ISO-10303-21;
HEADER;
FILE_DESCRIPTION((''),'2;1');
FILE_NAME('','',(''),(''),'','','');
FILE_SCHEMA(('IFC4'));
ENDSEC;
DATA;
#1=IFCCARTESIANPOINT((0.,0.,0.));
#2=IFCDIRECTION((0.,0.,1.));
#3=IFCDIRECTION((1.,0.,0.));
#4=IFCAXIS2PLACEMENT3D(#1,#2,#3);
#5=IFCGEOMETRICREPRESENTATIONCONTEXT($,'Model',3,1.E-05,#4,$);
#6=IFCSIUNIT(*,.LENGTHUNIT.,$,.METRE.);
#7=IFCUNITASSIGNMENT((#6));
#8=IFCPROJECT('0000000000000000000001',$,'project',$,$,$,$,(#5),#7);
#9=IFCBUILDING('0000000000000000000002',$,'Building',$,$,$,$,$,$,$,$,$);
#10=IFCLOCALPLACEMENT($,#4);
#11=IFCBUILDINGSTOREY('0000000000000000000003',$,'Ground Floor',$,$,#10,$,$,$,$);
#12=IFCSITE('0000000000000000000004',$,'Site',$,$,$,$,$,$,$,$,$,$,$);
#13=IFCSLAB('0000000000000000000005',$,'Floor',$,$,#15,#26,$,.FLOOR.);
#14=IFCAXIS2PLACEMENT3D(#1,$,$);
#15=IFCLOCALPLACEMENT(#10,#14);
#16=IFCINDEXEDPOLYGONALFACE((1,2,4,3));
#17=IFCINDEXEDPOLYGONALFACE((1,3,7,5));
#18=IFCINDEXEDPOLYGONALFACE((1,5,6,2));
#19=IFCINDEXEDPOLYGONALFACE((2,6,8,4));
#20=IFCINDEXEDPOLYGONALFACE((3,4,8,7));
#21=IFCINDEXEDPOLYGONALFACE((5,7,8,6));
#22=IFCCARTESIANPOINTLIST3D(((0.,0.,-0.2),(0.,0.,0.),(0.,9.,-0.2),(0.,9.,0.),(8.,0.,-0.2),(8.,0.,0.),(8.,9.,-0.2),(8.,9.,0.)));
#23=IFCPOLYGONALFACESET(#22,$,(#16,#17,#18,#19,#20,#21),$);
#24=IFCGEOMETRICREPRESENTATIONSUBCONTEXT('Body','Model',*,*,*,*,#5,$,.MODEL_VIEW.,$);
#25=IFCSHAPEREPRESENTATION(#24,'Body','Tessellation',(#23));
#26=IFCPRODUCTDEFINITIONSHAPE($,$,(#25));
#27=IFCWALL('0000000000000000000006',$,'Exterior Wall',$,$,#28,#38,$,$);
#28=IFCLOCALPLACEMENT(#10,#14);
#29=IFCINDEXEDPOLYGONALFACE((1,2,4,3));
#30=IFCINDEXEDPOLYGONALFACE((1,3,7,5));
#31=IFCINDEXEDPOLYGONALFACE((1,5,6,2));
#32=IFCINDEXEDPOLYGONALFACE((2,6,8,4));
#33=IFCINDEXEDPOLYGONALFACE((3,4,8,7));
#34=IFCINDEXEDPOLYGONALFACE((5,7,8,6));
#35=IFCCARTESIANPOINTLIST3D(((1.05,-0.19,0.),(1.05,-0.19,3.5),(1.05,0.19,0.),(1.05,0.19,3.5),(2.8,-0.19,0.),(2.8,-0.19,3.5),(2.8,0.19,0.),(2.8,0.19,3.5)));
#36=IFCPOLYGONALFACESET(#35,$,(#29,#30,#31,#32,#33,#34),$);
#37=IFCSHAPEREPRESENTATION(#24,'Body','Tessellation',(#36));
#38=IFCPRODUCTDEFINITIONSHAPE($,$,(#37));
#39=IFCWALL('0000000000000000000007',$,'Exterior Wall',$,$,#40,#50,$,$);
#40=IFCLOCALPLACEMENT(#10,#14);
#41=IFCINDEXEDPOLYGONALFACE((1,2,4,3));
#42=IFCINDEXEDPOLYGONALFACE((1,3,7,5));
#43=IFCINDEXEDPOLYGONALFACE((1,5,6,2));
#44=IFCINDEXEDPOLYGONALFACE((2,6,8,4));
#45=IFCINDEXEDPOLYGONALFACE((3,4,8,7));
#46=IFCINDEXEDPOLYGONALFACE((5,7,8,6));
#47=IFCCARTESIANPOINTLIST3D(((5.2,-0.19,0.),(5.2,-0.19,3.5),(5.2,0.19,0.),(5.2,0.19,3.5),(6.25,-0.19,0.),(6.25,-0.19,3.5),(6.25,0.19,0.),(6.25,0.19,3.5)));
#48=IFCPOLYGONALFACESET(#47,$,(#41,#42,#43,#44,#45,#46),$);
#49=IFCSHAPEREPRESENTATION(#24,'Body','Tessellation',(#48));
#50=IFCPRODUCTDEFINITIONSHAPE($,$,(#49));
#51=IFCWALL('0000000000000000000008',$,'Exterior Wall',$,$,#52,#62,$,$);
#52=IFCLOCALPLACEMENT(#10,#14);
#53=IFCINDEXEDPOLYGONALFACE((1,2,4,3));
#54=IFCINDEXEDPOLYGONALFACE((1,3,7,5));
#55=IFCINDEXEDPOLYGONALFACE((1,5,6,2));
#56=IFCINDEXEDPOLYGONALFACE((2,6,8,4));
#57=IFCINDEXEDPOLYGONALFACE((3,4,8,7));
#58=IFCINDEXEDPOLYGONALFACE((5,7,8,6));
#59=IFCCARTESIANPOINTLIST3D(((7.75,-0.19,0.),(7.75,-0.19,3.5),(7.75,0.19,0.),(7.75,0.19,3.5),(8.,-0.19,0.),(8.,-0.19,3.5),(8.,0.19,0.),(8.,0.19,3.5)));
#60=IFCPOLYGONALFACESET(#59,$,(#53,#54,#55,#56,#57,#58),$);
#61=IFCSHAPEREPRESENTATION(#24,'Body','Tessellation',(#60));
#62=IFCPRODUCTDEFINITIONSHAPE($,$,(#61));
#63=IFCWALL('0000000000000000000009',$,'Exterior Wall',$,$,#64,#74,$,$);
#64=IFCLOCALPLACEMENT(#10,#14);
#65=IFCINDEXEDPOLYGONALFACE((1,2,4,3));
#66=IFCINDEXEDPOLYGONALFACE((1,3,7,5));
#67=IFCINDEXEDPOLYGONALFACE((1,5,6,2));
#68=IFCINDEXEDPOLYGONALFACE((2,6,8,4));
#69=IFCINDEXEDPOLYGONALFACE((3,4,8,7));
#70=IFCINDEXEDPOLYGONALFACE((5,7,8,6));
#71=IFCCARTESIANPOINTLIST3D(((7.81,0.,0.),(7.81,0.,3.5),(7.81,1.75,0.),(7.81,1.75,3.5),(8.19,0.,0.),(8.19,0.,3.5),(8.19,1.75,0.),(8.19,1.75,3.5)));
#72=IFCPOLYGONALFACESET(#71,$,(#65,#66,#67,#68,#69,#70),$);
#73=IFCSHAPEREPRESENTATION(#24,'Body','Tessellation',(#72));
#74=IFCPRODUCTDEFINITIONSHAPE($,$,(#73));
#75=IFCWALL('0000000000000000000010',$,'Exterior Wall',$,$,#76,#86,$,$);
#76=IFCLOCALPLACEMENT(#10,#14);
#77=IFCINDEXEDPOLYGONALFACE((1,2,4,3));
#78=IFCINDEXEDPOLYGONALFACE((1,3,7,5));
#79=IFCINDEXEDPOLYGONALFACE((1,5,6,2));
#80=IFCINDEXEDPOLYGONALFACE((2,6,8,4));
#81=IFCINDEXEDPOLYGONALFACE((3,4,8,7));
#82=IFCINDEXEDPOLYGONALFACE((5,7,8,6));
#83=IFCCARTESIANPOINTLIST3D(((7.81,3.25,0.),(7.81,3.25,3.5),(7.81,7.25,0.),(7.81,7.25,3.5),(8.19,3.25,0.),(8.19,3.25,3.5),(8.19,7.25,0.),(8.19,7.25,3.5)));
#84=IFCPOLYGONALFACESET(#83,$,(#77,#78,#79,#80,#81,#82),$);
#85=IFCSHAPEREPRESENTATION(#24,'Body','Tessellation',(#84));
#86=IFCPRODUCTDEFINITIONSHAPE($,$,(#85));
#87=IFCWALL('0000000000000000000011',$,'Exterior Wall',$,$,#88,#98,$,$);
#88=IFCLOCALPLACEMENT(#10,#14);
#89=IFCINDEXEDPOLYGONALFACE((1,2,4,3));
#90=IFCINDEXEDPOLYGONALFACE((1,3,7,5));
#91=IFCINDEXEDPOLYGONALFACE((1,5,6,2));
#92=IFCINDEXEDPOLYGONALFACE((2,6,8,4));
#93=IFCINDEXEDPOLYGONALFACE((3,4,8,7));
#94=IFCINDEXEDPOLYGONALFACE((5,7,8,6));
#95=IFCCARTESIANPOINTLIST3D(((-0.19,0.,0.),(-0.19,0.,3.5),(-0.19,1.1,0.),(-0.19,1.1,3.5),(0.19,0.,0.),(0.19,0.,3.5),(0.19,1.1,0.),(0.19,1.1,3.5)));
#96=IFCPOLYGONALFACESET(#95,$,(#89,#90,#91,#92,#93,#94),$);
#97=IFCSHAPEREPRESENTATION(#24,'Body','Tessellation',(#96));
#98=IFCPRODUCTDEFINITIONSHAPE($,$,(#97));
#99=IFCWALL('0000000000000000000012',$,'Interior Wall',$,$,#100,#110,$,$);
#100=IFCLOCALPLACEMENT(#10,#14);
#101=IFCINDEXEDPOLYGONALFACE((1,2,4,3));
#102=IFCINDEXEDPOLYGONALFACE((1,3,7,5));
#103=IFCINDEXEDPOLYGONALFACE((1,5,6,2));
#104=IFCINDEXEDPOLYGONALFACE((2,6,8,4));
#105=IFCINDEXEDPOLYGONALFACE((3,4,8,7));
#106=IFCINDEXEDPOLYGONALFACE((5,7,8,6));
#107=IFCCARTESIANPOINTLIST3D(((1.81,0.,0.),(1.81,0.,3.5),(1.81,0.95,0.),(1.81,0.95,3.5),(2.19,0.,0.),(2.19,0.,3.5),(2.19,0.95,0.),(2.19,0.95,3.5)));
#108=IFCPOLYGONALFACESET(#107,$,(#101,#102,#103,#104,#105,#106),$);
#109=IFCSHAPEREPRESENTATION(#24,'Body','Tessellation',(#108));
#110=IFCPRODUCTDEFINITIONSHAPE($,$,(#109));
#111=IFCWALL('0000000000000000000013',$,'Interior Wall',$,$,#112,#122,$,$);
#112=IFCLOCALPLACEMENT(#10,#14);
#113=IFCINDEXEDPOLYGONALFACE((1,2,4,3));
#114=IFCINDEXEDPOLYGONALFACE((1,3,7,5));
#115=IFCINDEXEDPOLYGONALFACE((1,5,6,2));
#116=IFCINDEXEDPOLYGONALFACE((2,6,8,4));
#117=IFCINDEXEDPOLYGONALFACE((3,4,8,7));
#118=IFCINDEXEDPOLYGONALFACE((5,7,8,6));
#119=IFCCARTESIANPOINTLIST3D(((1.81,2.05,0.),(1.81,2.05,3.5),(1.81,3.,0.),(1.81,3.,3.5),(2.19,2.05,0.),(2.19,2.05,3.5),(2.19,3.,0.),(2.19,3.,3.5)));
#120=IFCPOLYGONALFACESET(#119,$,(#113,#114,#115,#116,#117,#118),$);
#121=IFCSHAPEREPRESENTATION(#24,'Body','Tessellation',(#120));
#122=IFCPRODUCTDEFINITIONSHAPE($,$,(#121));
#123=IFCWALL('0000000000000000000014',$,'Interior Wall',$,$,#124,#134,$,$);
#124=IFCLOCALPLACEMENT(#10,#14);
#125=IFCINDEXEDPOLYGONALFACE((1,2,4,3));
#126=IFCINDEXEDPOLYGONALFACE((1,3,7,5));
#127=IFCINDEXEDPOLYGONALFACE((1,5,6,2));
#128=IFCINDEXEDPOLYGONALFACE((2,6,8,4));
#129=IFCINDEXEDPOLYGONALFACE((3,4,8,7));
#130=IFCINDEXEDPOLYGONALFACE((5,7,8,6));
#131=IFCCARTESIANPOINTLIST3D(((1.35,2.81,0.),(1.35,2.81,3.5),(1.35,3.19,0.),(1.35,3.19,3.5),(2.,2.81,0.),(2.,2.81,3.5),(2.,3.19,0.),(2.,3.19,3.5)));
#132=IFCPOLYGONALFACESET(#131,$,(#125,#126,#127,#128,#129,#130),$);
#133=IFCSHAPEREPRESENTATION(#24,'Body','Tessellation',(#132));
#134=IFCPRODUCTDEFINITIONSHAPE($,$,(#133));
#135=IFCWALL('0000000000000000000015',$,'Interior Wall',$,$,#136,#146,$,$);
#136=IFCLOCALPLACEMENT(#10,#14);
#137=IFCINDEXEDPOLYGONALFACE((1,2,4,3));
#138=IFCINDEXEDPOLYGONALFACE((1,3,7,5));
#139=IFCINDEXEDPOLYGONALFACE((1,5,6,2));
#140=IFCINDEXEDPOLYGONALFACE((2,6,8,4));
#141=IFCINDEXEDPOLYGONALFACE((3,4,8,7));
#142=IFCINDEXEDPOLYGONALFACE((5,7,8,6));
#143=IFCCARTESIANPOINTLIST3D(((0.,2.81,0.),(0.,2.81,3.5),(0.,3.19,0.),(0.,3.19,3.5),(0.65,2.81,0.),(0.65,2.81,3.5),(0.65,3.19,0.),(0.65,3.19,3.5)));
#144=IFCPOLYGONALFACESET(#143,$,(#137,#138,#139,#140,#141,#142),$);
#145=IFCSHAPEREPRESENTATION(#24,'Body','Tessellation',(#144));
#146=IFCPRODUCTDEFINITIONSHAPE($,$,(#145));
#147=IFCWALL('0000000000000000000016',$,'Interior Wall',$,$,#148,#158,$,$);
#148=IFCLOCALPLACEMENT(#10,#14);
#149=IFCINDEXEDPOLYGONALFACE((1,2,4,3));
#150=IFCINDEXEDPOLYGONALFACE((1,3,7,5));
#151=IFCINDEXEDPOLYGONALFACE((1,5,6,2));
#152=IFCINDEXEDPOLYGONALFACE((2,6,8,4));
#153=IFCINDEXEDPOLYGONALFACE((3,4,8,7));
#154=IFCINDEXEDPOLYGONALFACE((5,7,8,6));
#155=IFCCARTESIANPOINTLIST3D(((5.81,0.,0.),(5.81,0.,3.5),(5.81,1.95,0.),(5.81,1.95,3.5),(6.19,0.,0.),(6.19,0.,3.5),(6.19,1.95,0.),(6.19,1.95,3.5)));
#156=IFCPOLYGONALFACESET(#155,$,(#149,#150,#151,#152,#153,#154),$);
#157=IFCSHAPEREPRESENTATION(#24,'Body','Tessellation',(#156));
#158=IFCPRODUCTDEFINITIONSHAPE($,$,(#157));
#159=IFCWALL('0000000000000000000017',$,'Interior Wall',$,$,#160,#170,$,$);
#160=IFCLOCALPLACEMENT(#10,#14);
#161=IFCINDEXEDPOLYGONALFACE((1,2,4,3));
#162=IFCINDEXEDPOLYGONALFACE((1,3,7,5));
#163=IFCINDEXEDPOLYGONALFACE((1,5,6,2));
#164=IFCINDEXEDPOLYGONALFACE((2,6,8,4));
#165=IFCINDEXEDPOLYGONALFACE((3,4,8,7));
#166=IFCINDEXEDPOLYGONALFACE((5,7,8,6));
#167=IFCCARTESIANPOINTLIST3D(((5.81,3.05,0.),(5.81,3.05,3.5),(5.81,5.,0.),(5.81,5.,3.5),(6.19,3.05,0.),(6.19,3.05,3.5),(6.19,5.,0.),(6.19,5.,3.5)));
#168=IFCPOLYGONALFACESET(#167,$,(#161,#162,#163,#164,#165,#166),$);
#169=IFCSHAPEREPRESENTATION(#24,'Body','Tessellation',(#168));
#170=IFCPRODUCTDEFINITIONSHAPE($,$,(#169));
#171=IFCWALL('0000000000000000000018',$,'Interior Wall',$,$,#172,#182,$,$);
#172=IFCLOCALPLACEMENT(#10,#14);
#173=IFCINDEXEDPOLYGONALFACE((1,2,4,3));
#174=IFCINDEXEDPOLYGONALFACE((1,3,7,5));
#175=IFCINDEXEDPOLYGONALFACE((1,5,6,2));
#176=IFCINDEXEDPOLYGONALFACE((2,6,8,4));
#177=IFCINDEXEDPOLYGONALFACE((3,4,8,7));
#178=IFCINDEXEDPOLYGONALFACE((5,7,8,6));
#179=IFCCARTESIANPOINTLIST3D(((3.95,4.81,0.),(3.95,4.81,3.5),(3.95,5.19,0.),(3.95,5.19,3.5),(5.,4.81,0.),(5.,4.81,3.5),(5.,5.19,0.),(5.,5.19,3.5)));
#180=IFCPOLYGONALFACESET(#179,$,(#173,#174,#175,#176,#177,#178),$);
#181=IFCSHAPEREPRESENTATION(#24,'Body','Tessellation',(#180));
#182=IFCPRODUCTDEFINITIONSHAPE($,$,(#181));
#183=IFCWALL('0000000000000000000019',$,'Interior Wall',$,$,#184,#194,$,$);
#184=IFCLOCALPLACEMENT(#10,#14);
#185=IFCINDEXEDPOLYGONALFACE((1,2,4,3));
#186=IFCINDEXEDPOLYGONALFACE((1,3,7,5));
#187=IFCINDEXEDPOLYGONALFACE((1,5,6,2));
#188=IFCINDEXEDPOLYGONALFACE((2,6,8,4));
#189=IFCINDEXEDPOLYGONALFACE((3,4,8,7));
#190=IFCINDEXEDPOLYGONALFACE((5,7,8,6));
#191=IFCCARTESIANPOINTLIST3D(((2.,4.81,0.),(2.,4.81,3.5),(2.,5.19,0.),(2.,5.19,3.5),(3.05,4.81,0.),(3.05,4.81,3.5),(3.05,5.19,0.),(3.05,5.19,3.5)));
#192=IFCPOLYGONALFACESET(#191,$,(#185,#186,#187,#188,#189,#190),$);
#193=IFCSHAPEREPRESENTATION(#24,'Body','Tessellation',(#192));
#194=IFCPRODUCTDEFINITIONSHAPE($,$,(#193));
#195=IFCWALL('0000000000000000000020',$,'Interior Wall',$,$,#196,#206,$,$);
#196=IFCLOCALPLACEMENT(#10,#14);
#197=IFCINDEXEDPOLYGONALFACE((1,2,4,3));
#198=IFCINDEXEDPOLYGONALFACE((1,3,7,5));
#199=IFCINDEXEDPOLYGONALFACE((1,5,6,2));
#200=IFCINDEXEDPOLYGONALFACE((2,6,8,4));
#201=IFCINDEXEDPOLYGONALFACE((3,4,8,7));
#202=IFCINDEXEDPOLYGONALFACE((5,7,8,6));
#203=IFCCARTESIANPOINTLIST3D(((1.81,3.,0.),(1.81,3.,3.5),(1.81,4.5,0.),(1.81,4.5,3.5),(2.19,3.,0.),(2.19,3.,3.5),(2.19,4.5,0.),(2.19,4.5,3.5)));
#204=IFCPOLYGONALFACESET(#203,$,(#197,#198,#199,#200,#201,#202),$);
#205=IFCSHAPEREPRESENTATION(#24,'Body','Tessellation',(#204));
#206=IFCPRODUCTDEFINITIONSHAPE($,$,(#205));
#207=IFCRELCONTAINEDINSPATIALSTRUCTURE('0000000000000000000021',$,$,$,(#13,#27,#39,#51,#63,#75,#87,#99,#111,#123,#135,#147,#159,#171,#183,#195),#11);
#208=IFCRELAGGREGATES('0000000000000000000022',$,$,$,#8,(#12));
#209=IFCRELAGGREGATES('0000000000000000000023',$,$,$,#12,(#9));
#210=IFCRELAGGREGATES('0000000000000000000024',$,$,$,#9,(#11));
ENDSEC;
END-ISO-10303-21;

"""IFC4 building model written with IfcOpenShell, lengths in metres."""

from ifc_helpers import new_model, si_unit, frame, origin_with_axes, place, context, subcontext, project, spatial, indexed_curve, outline, extrude, element, save


model = new_model("IFC4")

# Units and contexts
model_context = context("Model", 3, precision=1e-05, world=origin_with_axes())
body_context = subcontext(model_context, "Body", "Model", "MODEL_VIEW")
ifc_project = project(units=[si_unit("LENGTHUNIT", "METRE")], contexts=[model_context])

# Site, building, storey
site = spatial("IfcSite", under=ifc_project, Name="Site")
building = spatial("IfcBuilding", under=site, Name="Building")
storey_placement = place(None, origin_with_axes())
storey = spatial("IfcBuildingStorey", under=building, at=storey_placement, Name="Ground Floor")

# Slab
slab_placement = place(storey_placement, frame((0.0, 0.0, -0.2), z_axis=(0.0, 0.0, 1.0), x_axis=(1.0, 0.0, 0.0)))
element("IfcSlab", 1, at=slab_placement, inside=storey, Name="Floor", PredefinedType="FLOOR", context=body_context, shape_type="SweptSolid", body=[
    extrude(outline(indexed_curve([(0.0, 0.0), (8.0, 0.0), (8.0, 9.0), (0.0, 9.0)])), None, (0.0, 0.0, 1.0), 0.2),
])

# Walls
wall_1_placement = place(storey_placement, frame((1.05, 0.0, 0.0), z_axis=(0.0, 0.0, 1.0), x_axis=(1.0, 0.0, 0.0)))
element("IfcWall", 2, at=wall_1_placement, inside=storey, Name="Exterior Wall", context=body_context, shape_type="SweptSolid", body=[
    extrude(outline(indexed_curve([(0.0, 0.0), (0.0, 0.38), (1.75, 0.38), (1.75, 0.0), (0.0, 0.0)], self_intersect=False)), frame((0.0, -0.19, 0.0), z_axis=(0.0, 0.0, 1.0), x_axis=(1.0, 0.0, 0.0)), (0.0, 0.0, 1.0), 3.5),
])
wall_2_placement = place(storey_placement, frame((5.2, 0.0, 0.0), z_axis=(0.0, 0.0, 1.0), x_axis=(1.0, 0.0, 0.0)))
element("IfcWall", 3, at=wall_2_placement, inside=storey, Name="Exterior Wall", context=body_context, shape_type="SweptSolid", body=[
    extrude(outline(indexed_curve([(0.0, 0.0), (0.0, 0.38), (1.05, 0.38), (1.05, 0.0), (0.0, 0.0)], self_intersect=False)), frame((0.0, -0.19, 0.0), z_axis=(0.0, 0.0, 1.0), x_axis=(1.0, 0.0, 0.0)), (0.0, 0.0, 1.0), 3.5),
])
wall_3_placement = place(storey_placement, frame((7.75, 0.0, 0.0), z_axis=(0.0, 0.0, 1.0), x_axis=(1.0, 0.0, 0.0)))
element("IfcWall", 4, at=wall_3_placement, inside=storey, Name="Exterior Wall", context=body_context, shape_type="SweptSolid", body=[
    extrude(outline(indexed_curve([(0.0, 0.0), (0.0, 0.38), (0.25, 0.38), (0.25, 0.0), (0.0, 0.0)], self_intersect=False)), frame((0.0, -0.19, 0.0), z_axis=(0.0, 0.0, 1.0), x_axis=(1.0, 0.0, 0.0)), (0.0, 0.0, 1.0), 3.5),
])
wall_4_placement = place(storey_placement, frame((8.0, 0.0, 0.0), z_axis=(0.0, 0.0, 1.0), x_axis=(0.0, 1.0, 0.0)))
element("IfcWall", 5, at=wall_4_placement, inside=storey, Name="Exterior Wall", context=body_context, shape_type="SweptSolid", body=[
    extrude(outline(indexed_curve([(0.0, 0.0), (0.0, 0.38), (1.75, 0.38), (1.75, 0.0), (0.0, 0.0)], self_intersect=False)), frame((0.0, -0.19, 0.0), z_axis=(0.0, 0.0, 1.0), x_axis=(1.0, 0.0, 0.0)), (0.0, 0.0, 1.0), 3.5),
])
wall_5_placement = place(storey_placement, frame((8.0, 3.25, 0.0), z_axis=(0.0, 0.0, 1.0), x_axis=(0.0, 1.0, 0.0)))
element("IfcWall", 6, at=wall_5_placement, inside=storey, Name="Exterior Wall", context=body_context, shape_type="SweptSolid", body=[
    extrude(outline(indexed_curve([(0.0, 0.0), (0.0, 0.38), (4.0, 0.38), (4.0, 0.0), (0.0, 0.0)], self_intersect=False)), frame((0.0, -0.19, 0.0), z_axis=(0.0, 0.0, 1.0), x_axis=(1.0, 0.0, 0.0)), (0.0, 0.0, 1.0), 3.5),
])
wall_6_placement = place(storey_placement, frame((0.0, 1.1, 0.0), z_axis=(0.0, 0.0, 1.0), x_axis=(0.0, -1.0, 0.0)))
element("IfcWall", 7, at=wall_6_placement, inside=storey, Name="Exterior Wall", context=body_context, shape_type="SweptSolid", body=[
    extrude(outline(indexed_curve([(0.0, 0.0), (0.0, 0.38), (1.1, 0.38), (1.1, 0.0), (0.0, 0.0)], self_intersect=False)), frame((0.0, -0.19, 0.0), z_axis=(0.0, 0.0, 1.0), x_axis=(1.0, 0.0, 0.0)), (0.0, 0.0, 1.0), 3.5),
])
wall_7_placement = place(storey_placement, frame((2.0, 0.0, 0.0), z_axis=(0.0, 0.0, 1.0), x_axis=(0.0, 1.0, 0.0)))
element("IfcWall", 8, at=wall_7_placement, inside=storey, Name="Interior Wall", context=body_context, shape_type="SweptSolid", body=[
    extrude(outline(indexed_curve([(0.0, 0.0), (0.0, 0.38), (0.95, 0.38), (0.95, 0.0), (0.0, 0.0)], self_intersect=False)), frame((0.0, -0.19, 0.0), z_axis=(0.0, 0.0, 1.0), x_axis=(1.0, 0.0, 0.0)), (0.0, 0.0, 1.0), 3.5),
])
wall_8_placement = place(storey_placement, frame((2.0, 2.05, 0.0), z_axis=(0.0, 0.0, 1.0), x_axis=(0.0, 1.0, 0.0)))
element("IfcWall", 9, at=wall_8_placement, inside=storey, Name="Interior Wall", context=body_context, shape_type="SweptSolid", body=[
    extrude(outline(indexed_curve([(0.0, 0.0), (0.0, 0.38), (0.95, 0.38), (0.95, 0.0), (0.0, 0.0)], self_intersect=False)), frame((0.0, -0.19, 0.0), z_axis=(0.0, 0.0, 1.0), x_axis=(1.0, 0.0, 0.0)), (0.0, 0.0, 1.0), 3.5),
])
for number, where, z_axis, x_axis, name in (
    (10, (2.0, 3.0, 0.0), (0.0, 0.0, 1.0), (-1.0, 0.0, 0.0), "Interior Wall"),
    (11, (0.65, 3.0, 0.0), (0.0, 0.0, 1.0), (-1.0, 0.0, 0.0), "Interior Wall"),
):
    element("IfcWall", number, at=place(storey_placement, frame(where, z_axis=z_axis, x_axis=x_axis)), inside=storey, Name=name, context=body_context, shape_type="SweptSolid", body=[
        extrude(outline(indexed_curve([(0.0, 0.0), (0.0, 0.38), (0.65, 0.38), (0.65, 0.0), (0.0, 0.0)], self_intersect=False)), frame((0.0, -0.19, 0.0), z_axis=(0.0, 0.0, 1.0), x_axis=(1.0, 0.0, 0.0)), (0.0, 0.0, 1.0), 3.5),
    ])
wall_9_placement = place(storey_placement, frame((6.0, 0.0, 0.0), z_axis=(0.0, 0.0, 1.0), x_axis=(0.0, 1.0, 0.0)))
element("IfcWall", 12, at=wall_9_placement, inside=storey, Name="Interior Wall", context=body_context, shape_type="SweptSolid", body=[
    extrude(outline(indexed_curve([(0.0, 0.0), (0.0, 0.38), (1.95, 0.38), (1.95, 0.0), (0.0, 0.0)], self_intersect=False)), frame((0.0, -0.19, 0.0), z_axis=(0.0, 0.0, 1.0), x_axis=(1.0, 0.0, 0.0)), (0.0, 0.0, 1.0), 3.5),
])
wall_10_placement = place(storey_placement, frame((6.0, 3.05, 0.0), z_axis=(0.0, 0.0, 1.0), x_axis=(0.0, 1.0, 0.0)))
element("IfcWall", 13, at=wall_10_placement, inside=storey, Name="Interior Wall", context=body_context, shape_type="SweptSolid", body=[
    extrude(outline(indexed_curve([(0.0, 0.0), (0.0, 0.38), (1.95, 0.38), (1.95, 0.0), (0.0, 0.0)], self_intersect=False)), frame((0.0, -0.19, 0.0), z_axis=(0.0, 0.0, 1.0), x_axis=(1.0, 0.0, 0.0)), (0.0, 0.0, 1.0), 3.5),
])
for number, where, z_axis, x_axis, name in (
    (14, (5.0, 5.0, 0.0), (0.0, 0.0, 1.0), (-1.0, 0.0, 0.0), "Interior Wall"),
    (15, (3.05, 5.0, 0.0), (0.0, 0.0, 1.0), (-1.0, 0.0, 0.0), "Interior Wall"),
):
    element("IfcWall", number, at=place(storey_placement, frame(where, z_axis=z_axis, x_axis=x_axis)), inside=storey, Name=name, context=body_context, shape_type="SweptSolid", body=[
        extrude(outline(indexed_curve([(0.0, 0.0), (0.0, 0.38), (1.05, 0.38), (1.05, 0.0), (0.0, 0.0)], self_intersect=False)), frame((0.0, -0.19, 0.0), z_axis=(0.0, 0.0, 1.0), x_axis=(1.0, 0.0, 0.0)), (0.0, 0.0, 1.0), 3.5),
    ])
wall_11_placement = place(storey_placement, frame((2.0, 4.5, 0.0), z_axis=(0.0, 0.0, 1.0), x_axis=(0.0, -1.0, 0.0)))
element("IfcWall", 16, at=wall_11_placement, inside=storey, Name="Interior Wall", context=body_context, shape_type="SweptSolid", body=[
    extrude(outline(indexed_curve([(0.0, 0.0), (0.0, 0.38), (1.5, 0.38), (1.5, 0.0), (0.0, 0.0)], self_intersect=False)), frame((0.0, -0.19, 0.0), z_axis=(0.0, 0.0, 1.0), x_axis=(1.0, 0.0, 0.0)), (0.0, 0.0, 1.0), 3.5),
])

save(model, "model.ifc")
